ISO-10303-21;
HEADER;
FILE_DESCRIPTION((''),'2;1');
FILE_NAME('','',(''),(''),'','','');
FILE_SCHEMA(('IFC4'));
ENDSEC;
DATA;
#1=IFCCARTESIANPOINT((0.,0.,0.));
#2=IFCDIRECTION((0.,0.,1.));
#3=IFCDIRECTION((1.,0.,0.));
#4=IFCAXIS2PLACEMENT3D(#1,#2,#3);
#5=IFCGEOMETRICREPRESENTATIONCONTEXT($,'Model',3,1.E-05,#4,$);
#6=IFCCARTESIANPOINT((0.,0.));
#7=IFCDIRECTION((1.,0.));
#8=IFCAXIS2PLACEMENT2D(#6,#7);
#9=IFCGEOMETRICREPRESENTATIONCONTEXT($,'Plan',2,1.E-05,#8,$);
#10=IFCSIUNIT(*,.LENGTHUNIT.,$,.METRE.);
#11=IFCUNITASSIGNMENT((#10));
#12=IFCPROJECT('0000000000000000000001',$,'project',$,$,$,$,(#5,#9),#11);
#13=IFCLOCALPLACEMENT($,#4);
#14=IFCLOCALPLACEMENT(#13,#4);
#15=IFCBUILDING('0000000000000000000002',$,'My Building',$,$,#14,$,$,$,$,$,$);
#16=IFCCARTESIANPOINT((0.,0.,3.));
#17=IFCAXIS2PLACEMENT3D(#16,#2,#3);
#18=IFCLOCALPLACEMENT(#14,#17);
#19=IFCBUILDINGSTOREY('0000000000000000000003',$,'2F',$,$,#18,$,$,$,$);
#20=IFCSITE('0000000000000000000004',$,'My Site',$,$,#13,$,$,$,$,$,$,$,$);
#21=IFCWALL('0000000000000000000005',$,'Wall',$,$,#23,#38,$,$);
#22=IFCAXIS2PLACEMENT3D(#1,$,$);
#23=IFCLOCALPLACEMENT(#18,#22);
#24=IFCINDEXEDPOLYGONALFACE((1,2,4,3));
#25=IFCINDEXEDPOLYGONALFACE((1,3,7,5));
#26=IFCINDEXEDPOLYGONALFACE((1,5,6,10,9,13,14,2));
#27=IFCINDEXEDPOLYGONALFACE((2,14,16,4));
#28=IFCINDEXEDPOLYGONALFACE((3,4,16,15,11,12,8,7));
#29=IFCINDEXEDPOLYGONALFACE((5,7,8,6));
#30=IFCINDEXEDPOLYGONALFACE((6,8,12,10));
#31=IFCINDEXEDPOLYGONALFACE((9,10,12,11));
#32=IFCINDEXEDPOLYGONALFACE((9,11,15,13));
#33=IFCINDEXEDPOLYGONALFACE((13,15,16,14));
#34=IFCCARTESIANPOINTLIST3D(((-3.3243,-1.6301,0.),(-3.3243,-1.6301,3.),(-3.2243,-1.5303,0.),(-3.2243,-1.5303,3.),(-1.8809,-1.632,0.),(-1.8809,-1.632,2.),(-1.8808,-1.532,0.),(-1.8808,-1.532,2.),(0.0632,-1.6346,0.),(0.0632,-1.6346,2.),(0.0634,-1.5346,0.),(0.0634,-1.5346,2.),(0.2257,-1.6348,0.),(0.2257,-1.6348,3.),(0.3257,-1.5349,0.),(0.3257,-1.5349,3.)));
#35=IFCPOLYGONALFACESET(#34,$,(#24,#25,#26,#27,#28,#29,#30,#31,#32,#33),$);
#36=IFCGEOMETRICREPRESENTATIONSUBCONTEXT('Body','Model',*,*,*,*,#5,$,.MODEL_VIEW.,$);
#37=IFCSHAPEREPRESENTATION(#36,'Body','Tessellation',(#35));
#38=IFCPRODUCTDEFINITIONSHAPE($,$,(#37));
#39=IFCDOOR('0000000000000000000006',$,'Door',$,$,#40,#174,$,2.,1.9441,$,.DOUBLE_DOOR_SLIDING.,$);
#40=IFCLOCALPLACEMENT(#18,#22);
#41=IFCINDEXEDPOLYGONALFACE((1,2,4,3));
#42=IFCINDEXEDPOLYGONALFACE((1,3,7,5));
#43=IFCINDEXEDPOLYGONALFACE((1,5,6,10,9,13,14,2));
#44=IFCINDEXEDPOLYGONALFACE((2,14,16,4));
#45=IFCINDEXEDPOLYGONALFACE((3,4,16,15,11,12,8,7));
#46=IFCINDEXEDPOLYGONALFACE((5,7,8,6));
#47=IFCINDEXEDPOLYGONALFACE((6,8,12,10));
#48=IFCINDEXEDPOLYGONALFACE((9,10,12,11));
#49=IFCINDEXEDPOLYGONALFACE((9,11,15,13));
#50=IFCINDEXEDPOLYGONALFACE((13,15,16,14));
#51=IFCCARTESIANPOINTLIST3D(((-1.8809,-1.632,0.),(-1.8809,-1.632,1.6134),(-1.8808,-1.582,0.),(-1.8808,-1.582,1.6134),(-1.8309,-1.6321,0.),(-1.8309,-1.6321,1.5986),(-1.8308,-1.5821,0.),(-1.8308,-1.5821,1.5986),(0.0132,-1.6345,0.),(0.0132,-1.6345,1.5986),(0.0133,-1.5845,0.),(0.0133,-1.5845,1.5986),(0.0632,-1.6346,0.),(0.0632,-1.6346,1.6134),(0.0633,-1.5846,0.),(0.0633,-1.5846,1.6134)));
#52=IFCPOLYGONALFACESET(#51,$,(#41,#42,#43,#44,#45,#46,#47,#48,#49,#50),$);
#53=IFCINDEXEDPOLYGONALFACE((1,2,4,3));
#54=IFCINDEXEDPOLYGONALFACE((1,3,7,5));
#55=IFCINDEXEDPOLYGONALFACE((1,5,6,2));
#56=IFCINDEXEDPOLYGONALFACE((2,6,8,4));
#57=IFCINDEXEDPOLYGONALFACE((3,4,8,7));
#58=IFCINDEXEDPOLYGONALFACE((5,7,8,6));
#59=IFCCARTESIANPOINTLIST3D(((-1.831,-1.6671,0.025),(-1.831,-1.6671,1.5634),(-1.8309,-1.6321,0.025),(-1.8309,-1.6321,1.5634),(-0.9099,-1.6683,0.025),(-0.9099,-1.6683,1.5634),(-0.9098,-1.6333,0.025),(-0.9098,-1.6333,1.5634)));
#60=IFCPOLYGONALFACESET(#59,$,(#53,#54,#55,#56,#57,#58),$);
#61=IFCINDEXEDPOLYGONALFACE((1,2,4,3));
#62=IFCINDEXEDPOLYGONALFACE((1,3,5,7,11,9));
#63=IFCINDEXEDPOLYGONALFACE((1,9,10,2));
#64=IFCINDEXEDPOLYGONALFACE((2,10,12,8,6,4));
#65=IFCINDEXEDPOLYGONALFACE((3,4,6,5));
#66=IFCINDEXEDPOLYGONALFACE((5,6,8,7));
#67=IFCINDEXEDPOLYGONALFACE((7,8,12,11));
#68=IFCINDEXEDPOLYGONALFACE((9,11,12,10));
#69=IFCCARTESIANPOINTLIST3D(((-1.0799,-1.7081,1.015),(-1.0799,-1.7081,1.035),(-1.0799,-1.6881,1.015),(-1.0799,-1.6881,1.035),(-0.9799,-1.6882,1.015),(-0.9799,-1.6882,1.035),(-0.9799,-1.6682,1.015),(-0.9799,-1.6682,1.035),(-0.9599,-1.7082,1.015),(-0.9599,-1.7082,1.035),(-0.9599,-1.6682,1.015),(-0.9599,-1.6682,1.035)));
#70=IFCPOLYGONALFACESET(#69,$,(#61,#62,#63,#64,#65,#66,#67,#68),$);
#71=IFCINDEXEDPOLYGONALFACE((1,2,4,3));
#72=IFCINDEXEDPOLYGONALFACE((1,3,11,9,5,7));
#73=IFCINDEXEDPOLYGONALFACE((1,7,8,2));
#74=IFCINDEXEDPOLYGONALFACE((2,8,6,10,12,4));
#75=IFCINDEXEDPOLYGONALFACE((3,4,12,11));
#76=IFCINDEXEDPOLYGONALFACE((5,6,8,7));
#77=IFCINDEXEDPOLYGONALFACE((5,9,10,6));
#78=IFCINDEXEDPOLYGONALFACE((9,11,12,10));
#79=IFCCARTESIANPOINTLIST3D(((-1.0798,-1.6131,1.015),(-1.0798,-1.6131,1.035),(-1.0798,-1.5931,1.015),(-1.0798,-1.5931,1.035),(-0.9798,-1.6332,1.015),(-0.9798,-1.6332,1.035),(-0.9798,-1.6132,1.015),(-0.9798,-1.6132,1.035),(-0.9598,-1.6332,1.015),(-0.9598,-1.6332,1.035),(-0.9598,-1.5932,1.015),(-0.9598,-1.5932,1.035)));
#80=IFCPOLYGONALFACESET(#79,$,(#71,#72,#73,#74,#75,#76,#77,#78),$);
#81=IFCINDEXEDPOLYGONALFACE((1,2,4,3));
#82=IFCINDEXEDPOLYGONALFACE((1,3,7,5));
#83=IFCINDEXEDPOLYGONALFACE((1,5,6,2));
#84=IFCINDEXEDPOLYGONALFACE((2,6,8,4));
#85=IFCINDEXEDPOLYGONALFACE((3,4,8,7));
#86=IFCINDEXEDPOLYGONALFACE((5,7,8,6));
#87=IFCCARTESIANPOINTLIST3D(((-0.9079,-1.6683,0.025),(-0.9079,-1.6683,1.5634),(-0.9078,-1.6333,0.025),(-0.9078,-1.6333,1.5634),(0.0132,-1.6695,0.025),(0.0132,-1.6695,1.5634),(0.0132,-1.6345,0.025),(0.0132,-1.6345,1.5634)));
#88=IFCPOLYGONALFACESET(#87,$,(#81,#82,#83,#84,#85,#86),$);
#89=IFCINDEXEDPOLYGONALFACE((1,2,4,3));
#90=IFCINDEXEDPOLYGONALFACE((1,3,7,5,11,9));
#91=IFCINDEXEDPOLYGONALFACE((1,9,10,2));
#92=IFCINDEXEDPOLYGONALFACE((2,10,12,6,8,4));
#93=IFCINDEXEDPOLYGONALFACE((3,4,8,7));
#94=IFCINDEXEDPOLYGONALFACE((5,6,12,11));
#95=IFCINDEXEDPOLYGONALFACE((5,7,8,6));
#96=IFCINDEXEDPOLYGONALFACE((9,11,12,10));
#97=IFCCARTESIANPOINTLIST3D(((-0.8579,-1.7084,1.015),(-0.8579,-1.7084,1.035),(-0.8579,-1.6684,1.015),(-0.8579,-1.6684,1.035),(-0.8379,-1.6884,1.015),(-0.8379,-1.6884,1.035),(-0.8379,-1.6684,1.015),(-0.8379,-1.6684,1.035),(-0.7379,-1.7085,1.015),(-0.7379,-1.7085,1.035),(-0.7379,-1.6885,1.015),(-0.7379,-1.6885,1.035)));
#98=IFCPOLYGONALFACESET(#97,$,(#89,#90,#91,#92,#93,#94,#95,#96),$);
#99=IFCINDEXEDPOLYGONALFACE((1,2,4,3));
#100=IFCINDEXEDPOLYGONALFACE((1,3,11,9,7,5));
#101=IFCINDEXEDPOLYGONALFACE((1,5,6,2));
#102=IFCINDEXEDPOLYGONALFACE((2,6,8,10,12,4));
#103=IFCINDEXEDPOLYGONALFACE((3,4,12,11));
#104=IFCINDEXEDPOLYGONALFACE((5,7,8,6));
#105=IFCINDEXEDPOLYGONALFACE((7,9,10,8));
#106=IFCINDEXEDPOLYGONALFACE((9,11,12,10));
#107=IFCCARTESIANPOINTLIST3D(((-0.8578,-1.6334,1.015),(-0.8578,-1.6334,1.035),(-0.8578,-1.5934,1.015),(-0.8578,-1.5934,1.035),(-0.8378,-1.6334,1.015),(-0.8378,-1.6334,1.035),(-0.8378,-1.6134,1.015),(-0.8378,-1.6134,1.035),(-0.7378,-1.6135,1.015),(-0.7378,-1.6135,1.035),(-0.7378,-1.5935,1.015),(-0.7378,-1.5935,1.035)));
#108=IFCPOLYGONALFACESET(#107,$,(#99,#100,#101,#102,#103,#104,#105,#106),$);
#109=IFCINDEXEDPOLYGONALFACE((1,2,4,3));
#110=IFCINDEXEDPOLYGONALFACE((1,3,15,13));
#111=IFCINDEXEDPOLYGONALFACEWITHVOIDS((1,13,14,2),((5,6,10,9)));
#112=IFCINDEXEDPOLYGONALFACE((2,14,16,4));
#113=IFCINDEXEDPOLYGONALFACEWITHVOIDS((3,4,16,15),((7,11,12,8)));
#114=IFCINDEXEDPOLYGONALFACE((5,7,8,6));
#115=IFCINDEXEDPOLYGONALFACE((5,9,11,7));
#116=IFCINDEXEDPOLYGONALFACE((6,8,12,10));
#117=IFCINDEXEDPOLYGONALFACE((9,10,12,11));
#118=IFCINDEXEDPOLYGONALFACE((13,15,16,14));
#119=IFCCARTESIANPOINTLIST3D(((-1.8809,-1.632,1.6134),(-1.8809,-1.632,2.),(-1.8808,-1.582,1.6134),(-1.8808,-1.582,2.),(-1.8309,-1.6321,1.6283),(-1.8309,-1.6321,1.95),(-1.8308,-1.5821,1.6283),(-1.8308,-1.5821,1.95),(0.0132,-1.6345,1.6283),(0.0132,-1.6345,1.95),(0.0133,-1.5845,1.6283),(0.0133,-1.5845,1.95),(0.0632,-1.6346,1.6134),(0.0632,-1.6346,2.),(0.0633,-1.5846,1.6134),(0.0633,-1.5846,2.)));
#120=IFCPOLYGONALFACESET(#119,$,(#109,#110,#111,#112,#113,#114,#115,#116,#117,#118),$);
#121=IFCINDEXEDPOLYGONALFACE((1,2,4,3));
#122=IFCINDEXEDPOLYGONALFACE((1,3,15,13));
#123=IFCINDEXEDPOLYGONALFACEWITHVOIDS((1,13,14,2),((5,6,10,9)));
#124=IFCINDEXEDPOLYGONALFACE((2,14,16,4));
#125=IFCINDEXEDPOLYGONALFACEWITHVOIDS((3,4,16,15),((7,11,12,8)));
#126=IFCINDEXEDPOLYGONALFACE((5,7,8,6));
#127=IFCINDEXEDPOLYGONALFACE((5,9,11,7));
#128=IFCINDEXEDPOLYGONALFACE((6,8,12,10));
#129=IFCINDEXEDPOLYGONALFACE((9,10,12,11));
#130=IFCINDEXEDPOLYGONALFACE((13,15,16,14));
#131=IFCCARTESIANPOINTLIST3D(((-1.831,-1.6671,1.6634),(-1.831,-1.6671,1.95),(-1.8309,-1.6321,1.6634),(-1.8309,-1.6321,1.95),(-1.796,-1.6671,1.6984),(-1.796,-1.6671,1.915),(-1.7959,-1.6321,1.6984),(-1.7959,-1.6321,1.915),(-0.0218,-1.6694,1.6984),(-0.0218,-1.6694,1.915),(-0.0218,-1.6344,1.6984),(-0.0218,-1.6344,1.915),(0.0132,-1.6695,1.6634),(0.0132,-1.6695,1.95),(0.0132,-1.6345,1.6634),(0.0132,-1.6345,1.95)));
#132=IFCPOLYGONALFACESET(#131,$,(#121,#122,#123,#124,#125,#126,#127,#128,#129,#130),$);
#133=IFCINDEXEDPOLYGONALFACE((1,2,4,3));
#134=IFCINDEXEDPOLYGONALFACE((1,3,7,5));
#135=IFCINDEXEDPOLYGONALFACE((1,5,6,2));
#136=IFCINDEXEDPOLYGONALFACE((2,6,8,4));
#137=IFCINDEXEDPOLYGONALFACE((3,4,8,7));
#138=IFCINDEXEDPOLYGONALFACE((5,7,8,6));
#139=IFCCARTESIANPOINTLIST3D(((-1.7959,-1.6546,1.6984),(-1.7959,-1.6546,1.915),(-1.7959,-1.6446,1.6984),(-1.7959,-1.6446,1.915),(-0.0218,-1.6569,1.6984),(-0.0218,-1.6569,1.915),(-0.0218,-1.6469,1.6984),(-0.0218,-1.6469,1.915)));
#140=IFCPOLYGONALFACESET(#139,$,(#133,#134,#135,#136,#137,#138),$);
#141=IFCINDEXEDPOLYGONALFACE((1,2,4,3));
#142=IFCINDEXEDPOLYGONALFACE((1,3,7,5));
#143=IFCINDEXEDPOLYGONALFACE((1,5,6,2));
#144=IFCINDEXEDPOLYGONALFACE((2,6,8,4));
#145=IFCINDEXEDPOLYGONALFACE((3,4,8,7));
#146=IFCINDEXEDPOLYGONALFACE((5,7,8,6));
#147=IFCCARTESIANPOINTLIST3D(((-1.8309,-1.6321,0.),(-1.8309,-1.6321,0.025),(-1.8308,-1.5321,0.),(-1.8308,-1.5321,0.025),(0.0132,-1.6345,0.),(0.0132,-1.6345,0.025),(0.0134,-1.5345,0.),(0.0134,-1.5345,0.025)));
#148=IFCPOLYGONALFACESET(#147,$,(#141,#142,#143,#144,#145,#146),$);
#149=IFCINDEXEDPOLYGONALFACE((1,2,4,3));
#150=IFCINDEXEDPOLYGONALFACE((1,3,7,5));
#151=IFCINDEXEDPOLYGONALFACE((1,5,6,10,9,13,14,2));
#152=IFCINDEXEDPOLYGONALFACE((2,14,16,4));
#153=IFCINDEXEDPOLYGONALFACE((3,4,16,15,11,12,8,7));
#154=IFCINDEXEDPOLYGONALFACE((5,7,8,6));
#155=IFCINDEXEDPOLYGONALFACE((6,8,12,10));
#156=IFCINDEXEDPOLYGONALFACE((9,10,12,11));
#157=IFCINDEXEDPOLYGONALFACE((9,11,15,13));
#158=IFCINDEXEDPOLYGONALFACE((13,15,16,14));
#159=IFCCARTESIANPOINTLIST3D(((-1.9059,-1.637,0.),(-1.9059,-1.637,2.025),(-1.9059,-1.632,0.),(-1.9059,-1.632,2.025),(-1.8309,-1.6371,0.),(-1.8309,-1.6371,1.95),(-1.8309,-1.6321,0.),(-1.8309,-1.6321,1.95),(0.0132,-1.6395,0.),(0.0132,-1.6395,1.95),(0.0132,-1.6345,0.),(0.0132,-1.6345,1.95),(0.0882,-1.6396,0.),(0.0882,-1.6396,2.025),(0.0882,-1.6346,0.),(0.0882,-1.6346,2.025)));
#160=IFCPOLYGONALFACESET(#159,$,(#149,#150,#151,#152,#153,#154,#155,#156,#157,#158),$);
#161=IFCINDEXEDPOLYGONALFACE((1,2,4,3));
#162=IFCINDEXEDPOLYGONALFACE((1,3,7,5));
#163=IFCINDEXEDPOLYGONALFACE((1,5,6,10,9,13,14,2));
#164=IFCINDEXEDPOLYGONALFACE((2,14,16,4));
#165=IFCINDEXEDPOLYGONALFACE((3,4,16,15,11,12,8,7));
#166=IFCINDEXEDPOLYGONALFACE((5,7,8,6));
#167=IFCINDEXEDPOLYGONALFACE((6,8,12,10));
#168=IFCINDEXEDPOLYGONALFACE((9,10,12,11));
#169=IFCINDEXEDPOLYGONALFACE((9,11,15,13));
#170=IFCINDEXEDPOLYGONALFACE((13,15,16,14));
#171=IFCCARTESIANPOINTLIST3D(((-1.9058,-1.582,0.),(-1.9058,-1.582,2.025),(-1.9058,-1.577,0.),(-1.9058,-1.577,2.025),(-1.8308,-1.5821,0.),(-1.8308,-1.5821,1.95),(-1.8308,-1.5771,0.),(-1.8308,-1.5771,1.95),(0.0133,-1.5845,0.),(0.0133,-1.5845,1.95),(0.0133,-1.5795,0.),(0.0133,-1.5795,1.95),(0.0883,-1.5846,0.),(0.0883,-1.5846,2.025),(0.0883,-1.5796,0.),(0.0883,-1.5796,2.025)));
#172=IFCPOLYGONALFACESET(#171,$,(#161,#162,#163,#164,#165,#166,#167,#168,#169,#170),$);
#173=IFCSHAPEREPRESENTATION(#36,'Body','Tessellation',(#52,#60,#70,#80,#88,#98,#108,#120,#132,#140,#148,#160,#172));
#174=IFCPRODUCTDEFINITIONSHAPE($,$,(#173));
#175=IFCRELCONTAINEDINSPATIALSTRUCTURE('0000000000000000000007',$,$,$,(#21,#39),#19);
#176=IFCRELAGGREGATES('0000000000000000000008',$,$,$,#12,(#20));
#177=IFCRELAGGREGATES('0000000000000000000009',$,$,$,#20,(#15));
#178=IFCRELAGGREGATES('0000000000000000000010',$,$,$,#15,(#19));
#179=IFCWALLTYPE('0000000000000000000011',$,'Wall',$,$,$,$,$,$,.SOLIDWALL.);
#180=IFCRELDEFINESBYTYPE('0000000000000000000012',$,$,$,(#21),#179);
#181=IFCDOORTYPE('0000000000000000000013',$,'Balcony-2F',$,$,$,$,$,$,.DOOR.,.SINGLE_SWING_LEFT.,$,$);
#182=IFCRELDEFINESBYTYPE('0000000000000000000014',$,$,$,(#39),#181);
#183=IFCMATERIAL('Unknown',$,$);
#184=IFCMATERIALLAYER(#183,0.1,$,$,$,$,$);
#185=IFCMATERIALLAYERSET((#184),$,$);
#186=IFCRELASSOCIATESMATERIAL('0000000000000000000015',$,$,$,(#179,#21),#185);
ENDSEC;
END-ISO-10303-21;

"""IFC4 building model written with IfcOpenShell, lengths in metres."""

from ifc_helpers import new_model, entity, si_unit, frame, origin_with_axes, origin_2d_with_axis, place, context, subcontext, project, spatial, line, indexed_curve, outline, extrude, shape, source, transform, mapped, material, layer, layer_set, layer_usage, type_object, type_shapes, element, fill, save


model = new_model("IFC4")

# Units and contexts
model_context = context("Model", 3, precision=1e-05, world=origin_with_axes())
plan_context = context("Plan", 2, precision=1e-05, world=origin_2d_with_axis())
body_context_1 = subcontext(model_context, "Body", "Model", "MODEL_VIEW")
body_context_2 = subcontext(plan_context, "Body", "Plan", "PLAN_VIEW")
ifc_project = project(units=[si_unit("LENGTHUNIT", "METRE")], contexts=[model_context, plan_context])

# Site, building, storey
site_placement = place(None, origin_with_axes())
site = spatial("IfcSite", under=ifc_project, at=site_placement, Name="My Site")
building_placement = place(site_placement, origin_with_axes())
building = spatial("IfcBuilding", under=site, at=building_placement, Name="My Building")
storey_placement = place(building_placement, frame((0.0, 0.0, 3.0), z_axis=(0.0, 0.0, 1.0), x_axis=(1.0, 0.0, 0.0)))
storey = spatial("IfcBuildingStorey", under=building, at=storey_placement, Name="2F")

# Shared definitions
ifc_material = material(Name="Unknown")

# Wall, opening, door
ifc_layer = layer(ifc_material, 0.1)
ifc_layer_set = layer_set([ifc_layer])
ifc_layer_usage_1 = layer_usage(ifc_layer_set, "AXIS2", "POSITIVE", 0.0)
wall_type = type_object("IfcWallType", Name="Wall", PredefinedType="SOLIDWALL", material=ifc_layer_set)
wall_1_placement = place(storey_placement, frame((-3.3243, -1.6301, 0.0), z_axis=(0.0, 0.0, 1.0), x_axis=(0.999999, -0.001304, 0.0)))
wall_1 = element("IfcWall", 1, at=wall_1_placement, inside=storey, type_object=wall_type, material=ifc_layer_usage_1, Name="Wall", context=body_context_1, shape_type="SweptSolid", body=[
    extrude(outline(indexed_curve([(0.0, 0.0), (0.0999, 0.1), (3.6499, 0.1), (3.55, 0.0)], segments=[line(1, 2, 3, 4, 1)])), origin_with_axes(), (0.0, 0.0, 1.0), 3.0),
])
shared_shape_1 = source(origin_with_axes(), body_context_1, "Body", "SweptSolid", [
    extrude(outline(indexed_curve([(0.0, 0.0), (1.9441, 0.0), (1.9441, 2.0), (0.0, 2.0)], segments=[line(1, 2, 3, 4, 1)])), frame((0.0, -0.6, 0.0), z_axis=(0.0, -1.0, 0.0), x_axis=(1.0, 0.0, 0.0)), (0.0, 0.0, -1.0), 1.2),
])
opening_1_placement = place(wall_1_placement, frame((1.4434, 0.0, 0.0), z_axis=(0.0, 0.0, 1.0), x_axis=(1.0, 0.0, 0.0)))
opening_1 = element("IfcOpeningElement", 2, at=opening_1_placement, cuts=wall_1, PredefinedType="OPENING", context=body_context_1, shape_type="MappedRepresentation", body=[
    mapped(shared_shape_1, transform((0.0, 0.0, 0.0), x_axis=(1.0, 0.0, 0.0), y_axis=(0.0, 1.0, 0.0), z_axis=(0.0, 0.0, 1.0), scale=1.0)),
])
door_type_1 = type_object("IfcDoorType", Name="Balcony-2F", OperationType="SINGLE_SWING_LEFT", PredefinedType="DOOR")
shared_shape_2 = source(origin_with_axes(), body_context_1, "Body", "SweptSolid", [
    extrude(outline(indexed_curve([(0.0, 0.0), (0.0, 1.6134), (1.9441, 1.6134), (1.9441, 0.0), (1.8941, 0.0), (1.8941, 1.5986), (0.05, 1.5986), (0.05, 0.0)], segments=[line(1, 2, 3, 4, 5, 6, 7, 8, 1)])), frame((0.0, 0.0, 0.0), z_axis=(0.0, -1.0, 0.0), x_axis=(1.0, 0.0, 0.0)), (0.0, 0.0, -1.0), 0.05),
    extrude(outline(indexed_curve([(0.0, 0.0), (0.9211, 0.0), (0.9211, 0.035), (0.0, 0.035)], segments=[line(1, 2, 3, 4, 1)])), frame((0.05, -0.035, 0.025), z_axis=(0.0, 0.0, 1.0), x_axis=(1.0, 0.0, 0.0)), (0.0, 0.0, 1.0), 1.5384),
    extrude(outline(indexed_curve([(0.0, 0.0), (0.0, -0.04), (-0.12, -0.04), (-0.12, -0.02), (-0.02, -0.02), (-0.02, 0.0)], segments=[line(1, 2, 3, 4, 5, 6, 1)])), frame((0.9211, -0.035, 1.015), z_axis=(0.0, 0.0, 1.0), x_axis=(1.0, 0.0, 0.0)), (0.0, 0.0, 1.0), 0.02),
    extrude(outline(indexed_curve([(0.0, 0.0), (0.0, 0.04), (-0.12, 0.04), (-0.12, 0.02), (-0.02, 0.02), (-0.02, 0.0)], segments=[line(1, 2, 3, 4, 5, 6, 1)])), frame((0.9211, 0.0, 1.015), z_axis=(0.0, 0.0, 1.0), x_axis=(1.0, 0.0, 0.0)), (0.0, 0.0, 1.0), 0.02),
    extrude(outline(indexed_curve([(0.0, 0.0), (-0.9211, 0.0), (-0.9211, 0.035), (0.0, 0.035)], segments=[line(1, 2, 3, 4, 1)])), frame((1.8941, -0.035, 0.025), z_axis=(0.0, 0.0, 1.0), x_axis=(1.0, 0.0, 0.0)), (0.0, 0.0, 1.0), 1.5384),
    extrude(outline(indexed_curve([(0.0, 0.0), (0.0, -0.04), (0.12, -0.04), (0.12, -0.02), (0.02, -0.02), (0.02, 0.0)], segments=[line(1, 2, 3, 4, 5, 6, 1)])), frame((1.0231, -0.035, 1.015), z_axis=(0.0, 0.0, 1.0), x_axis=(1.0, 0.0, 0.0)), (0.0, 0.0, 1.0), 0.02),
    extrude(outline(indexed_curve([(0.0, 0.0), (0.0, 0.04), (0.12, 0.04), (0.12, 0.02), (0.02, 0.02), (0.02, 0.0)], segments=[line(1, 2, 3, 4, 5, 6, 1)])), frame((1.0231, 0.0, 1.015), z_axis=(0.0, 0.0, 1.0), x_axis=(1.0, 0.0, 0.0)), (0.0, 0.0, 1.0), 0.02),
    extrude(outline(indexed_curve([(0.0, 0.0), (1.9441, 0.0), (1.9441, 0.3866), (0.0, 0.3866)], segments=[line(1, 2, 3, 4, 1)]), holes=[indexed_curve([(0.05, 0.0148), (1.8941, 0.0148), (1.8941, 0.3366), (0.05, 0.3366)], segments=[line(1, 2, 3, 4, 1)])]), frame((0.0, 0.0, 1.6134), z_axis=(0.0, -1.0, 0.0), x_axis=(1.0, 0.0, 0.0)), (0.0, 0.0, -1.0), 0.05),
    extrude(outline(indexed_curve([(0.0, 0.0), (1.8441, 0.0), (1.8441, 0.2866), (0.0, 0.2866)], segments=[line(1, 2, 3, 4, 1)]), holes=[indexed_curve([(0.035, 0.035), (1.8091, 0.035), (1.8091, 0.2516), (0.035, 0.2516)], segments=[line(1, 2, 3, 4, 1)])]), frame((0.05, -0.035, 1.6634), z_axis=(0.0, -1.0, 0.0), x_axis=(1.0, 0.0, 0.0)), (0.0, 0.0, -1.0), 0.035),
    extrude(outline(indexed_curve([(0.035, 0.035), (1.8091, 0.035), (1.8091, 0.2516), (0.035, 0.2516)], segments=[line(1, 2, 3, 4, 1)])), frame((0.05, -0.0225, 1.6634), z_axis=(0.0, -1.0, 0.0), x_axis=(1.0, 0.0, 0.0)), (0.0, 0.0, -1.0), 0.01),
    extrude(outline(indexed_curve([(0.0, 0.0), (1.8441, 0.0), (1.8441, 0.1), (0.0, 0.1)], segments=[line(1, 2, 3, 4, 1)])), frame((0.05, 0.0, 0.0), z_axis=(0.0, 0.0, 1.0), x_axis=(1.0, 0.0, 0.0)), (0.0, 0.0, 1.0), 0.025),
    extrude(outline(indexed_curve([(0.0, 0.0), (0.0, 2.025), (1.9941, 2.025), (1.9941, 0.0), (1.9191, 0.0), (1.9191, 1.95), (0.075, 1.95), (0.075, 0.0)], segments=[line(1, 2, 3, 4, 5, 6, 7, 8, 1)])), frame((-0.025, -0.005, 0.0), z_axis=(0.0, -1.0, 0.0), x_axis=(1.0, 0.0, 0.0)), (0.0, 0.0, -1.0), 0.005),
    extrude(outline(indexed_curve([(0.0, 0.0), (0.0, 2.025), (1.9941, 2.025), (1.9941, 0.0), (1.9191, 0.0), (1.9191, 1.95), (0.075, 1.95), (0.075, 0.0)], segments=[line(1, 2, 3, 4, 5, 6, 7, 8, 1)])), frame((-0.025, 0.05, 0.0), z_axis=(0.0, -1.0, 0.0), x_axis=(1.0, 0.0, 0.0)), (0.0, 0.0, -1.0), 0.005),
])
shared_shape_3 = source(origin_with_axes(), body_context_2, "Body", "Curve2D", [
    entity("IfcIndexedPolyCurve", entity("IfcCartesianPointList2D", [[0.0, 0.0], [0.05, 0.0], [0.05, 0.05], [0.0, 0.05]]), [entity("IfcLineIndex", [1, 2, 3, 4, 1])]),
    entity("IfcIndexedPolyCurve", entity("IfcCartesianPointList2D", [[1.9441, 0.0], [1.8941, 0.0], [1.8941, 0.05], [1.9441, 0.05]]), [entity("IfcLineIndex", [1, 2, 3, 4, 1])]),
    entity("IfcIndexedPolyCurve", entity("IfcCartesianPointList2D", [[-0.411, -0.035], [0.511, -0.035], [0.511, 0.0], [-0.411, 0.0]]), [entity("IfcLineIndex", [1, 2, 3, 4, 1])]),
    entity("IfcIndexedPolyCurve", entity("IfcCartesianPointList2D", [[2.3552, -0.035], [1.4331, -0.035], [1.4331, 0.0], [2.3552, 0.0]]), [entity("IfcLineIndex", [1, 2, 3, 4, 1])]),
])
type_shapes(door_type_1, [shared_shape_2, shared_shape_3])
door_1_placement = place(opening_1_placement, frame((0.0, 0.0, 0.0), z_axis=(0.0, 0.0, 1.0), x_axis=(1.0, 0.0, 0.0)))
door_1 = element("IfcDoor", 3, at=door_1_placement, inside=storey, type_object=door_type_1, Name="Door", OperationType="DOUBLE_DOOR_SLIDING", OverallHeight=2.0, OverallWidth=1.9441, shapes=[
    shape(body_context_1, "Body", "MappedRepresentation", [mapped(shared_shape_2, transform((0.0, 0.0, 0.0), x_axis=(1.0, 0.0, 0.0), y_axis=(0.0, 1.0, 0.0), z_axis=(0.0, 0.0, 1.0), scale=1.0))]),
    shape(body_context_2, "Body", "MappedRepresentation", [mapped(shared_shape_3, transform((0.0, 0.0, 0.0), x_axis=(1.0, 0.0, 0.0), y_axis=(0.0, 1.0, 0.0), z_axis=(0.0, 0.0, 1.0), scale=1.0))]),
])
fill(opening_1, door_1)

save(model, "model.ifc")
